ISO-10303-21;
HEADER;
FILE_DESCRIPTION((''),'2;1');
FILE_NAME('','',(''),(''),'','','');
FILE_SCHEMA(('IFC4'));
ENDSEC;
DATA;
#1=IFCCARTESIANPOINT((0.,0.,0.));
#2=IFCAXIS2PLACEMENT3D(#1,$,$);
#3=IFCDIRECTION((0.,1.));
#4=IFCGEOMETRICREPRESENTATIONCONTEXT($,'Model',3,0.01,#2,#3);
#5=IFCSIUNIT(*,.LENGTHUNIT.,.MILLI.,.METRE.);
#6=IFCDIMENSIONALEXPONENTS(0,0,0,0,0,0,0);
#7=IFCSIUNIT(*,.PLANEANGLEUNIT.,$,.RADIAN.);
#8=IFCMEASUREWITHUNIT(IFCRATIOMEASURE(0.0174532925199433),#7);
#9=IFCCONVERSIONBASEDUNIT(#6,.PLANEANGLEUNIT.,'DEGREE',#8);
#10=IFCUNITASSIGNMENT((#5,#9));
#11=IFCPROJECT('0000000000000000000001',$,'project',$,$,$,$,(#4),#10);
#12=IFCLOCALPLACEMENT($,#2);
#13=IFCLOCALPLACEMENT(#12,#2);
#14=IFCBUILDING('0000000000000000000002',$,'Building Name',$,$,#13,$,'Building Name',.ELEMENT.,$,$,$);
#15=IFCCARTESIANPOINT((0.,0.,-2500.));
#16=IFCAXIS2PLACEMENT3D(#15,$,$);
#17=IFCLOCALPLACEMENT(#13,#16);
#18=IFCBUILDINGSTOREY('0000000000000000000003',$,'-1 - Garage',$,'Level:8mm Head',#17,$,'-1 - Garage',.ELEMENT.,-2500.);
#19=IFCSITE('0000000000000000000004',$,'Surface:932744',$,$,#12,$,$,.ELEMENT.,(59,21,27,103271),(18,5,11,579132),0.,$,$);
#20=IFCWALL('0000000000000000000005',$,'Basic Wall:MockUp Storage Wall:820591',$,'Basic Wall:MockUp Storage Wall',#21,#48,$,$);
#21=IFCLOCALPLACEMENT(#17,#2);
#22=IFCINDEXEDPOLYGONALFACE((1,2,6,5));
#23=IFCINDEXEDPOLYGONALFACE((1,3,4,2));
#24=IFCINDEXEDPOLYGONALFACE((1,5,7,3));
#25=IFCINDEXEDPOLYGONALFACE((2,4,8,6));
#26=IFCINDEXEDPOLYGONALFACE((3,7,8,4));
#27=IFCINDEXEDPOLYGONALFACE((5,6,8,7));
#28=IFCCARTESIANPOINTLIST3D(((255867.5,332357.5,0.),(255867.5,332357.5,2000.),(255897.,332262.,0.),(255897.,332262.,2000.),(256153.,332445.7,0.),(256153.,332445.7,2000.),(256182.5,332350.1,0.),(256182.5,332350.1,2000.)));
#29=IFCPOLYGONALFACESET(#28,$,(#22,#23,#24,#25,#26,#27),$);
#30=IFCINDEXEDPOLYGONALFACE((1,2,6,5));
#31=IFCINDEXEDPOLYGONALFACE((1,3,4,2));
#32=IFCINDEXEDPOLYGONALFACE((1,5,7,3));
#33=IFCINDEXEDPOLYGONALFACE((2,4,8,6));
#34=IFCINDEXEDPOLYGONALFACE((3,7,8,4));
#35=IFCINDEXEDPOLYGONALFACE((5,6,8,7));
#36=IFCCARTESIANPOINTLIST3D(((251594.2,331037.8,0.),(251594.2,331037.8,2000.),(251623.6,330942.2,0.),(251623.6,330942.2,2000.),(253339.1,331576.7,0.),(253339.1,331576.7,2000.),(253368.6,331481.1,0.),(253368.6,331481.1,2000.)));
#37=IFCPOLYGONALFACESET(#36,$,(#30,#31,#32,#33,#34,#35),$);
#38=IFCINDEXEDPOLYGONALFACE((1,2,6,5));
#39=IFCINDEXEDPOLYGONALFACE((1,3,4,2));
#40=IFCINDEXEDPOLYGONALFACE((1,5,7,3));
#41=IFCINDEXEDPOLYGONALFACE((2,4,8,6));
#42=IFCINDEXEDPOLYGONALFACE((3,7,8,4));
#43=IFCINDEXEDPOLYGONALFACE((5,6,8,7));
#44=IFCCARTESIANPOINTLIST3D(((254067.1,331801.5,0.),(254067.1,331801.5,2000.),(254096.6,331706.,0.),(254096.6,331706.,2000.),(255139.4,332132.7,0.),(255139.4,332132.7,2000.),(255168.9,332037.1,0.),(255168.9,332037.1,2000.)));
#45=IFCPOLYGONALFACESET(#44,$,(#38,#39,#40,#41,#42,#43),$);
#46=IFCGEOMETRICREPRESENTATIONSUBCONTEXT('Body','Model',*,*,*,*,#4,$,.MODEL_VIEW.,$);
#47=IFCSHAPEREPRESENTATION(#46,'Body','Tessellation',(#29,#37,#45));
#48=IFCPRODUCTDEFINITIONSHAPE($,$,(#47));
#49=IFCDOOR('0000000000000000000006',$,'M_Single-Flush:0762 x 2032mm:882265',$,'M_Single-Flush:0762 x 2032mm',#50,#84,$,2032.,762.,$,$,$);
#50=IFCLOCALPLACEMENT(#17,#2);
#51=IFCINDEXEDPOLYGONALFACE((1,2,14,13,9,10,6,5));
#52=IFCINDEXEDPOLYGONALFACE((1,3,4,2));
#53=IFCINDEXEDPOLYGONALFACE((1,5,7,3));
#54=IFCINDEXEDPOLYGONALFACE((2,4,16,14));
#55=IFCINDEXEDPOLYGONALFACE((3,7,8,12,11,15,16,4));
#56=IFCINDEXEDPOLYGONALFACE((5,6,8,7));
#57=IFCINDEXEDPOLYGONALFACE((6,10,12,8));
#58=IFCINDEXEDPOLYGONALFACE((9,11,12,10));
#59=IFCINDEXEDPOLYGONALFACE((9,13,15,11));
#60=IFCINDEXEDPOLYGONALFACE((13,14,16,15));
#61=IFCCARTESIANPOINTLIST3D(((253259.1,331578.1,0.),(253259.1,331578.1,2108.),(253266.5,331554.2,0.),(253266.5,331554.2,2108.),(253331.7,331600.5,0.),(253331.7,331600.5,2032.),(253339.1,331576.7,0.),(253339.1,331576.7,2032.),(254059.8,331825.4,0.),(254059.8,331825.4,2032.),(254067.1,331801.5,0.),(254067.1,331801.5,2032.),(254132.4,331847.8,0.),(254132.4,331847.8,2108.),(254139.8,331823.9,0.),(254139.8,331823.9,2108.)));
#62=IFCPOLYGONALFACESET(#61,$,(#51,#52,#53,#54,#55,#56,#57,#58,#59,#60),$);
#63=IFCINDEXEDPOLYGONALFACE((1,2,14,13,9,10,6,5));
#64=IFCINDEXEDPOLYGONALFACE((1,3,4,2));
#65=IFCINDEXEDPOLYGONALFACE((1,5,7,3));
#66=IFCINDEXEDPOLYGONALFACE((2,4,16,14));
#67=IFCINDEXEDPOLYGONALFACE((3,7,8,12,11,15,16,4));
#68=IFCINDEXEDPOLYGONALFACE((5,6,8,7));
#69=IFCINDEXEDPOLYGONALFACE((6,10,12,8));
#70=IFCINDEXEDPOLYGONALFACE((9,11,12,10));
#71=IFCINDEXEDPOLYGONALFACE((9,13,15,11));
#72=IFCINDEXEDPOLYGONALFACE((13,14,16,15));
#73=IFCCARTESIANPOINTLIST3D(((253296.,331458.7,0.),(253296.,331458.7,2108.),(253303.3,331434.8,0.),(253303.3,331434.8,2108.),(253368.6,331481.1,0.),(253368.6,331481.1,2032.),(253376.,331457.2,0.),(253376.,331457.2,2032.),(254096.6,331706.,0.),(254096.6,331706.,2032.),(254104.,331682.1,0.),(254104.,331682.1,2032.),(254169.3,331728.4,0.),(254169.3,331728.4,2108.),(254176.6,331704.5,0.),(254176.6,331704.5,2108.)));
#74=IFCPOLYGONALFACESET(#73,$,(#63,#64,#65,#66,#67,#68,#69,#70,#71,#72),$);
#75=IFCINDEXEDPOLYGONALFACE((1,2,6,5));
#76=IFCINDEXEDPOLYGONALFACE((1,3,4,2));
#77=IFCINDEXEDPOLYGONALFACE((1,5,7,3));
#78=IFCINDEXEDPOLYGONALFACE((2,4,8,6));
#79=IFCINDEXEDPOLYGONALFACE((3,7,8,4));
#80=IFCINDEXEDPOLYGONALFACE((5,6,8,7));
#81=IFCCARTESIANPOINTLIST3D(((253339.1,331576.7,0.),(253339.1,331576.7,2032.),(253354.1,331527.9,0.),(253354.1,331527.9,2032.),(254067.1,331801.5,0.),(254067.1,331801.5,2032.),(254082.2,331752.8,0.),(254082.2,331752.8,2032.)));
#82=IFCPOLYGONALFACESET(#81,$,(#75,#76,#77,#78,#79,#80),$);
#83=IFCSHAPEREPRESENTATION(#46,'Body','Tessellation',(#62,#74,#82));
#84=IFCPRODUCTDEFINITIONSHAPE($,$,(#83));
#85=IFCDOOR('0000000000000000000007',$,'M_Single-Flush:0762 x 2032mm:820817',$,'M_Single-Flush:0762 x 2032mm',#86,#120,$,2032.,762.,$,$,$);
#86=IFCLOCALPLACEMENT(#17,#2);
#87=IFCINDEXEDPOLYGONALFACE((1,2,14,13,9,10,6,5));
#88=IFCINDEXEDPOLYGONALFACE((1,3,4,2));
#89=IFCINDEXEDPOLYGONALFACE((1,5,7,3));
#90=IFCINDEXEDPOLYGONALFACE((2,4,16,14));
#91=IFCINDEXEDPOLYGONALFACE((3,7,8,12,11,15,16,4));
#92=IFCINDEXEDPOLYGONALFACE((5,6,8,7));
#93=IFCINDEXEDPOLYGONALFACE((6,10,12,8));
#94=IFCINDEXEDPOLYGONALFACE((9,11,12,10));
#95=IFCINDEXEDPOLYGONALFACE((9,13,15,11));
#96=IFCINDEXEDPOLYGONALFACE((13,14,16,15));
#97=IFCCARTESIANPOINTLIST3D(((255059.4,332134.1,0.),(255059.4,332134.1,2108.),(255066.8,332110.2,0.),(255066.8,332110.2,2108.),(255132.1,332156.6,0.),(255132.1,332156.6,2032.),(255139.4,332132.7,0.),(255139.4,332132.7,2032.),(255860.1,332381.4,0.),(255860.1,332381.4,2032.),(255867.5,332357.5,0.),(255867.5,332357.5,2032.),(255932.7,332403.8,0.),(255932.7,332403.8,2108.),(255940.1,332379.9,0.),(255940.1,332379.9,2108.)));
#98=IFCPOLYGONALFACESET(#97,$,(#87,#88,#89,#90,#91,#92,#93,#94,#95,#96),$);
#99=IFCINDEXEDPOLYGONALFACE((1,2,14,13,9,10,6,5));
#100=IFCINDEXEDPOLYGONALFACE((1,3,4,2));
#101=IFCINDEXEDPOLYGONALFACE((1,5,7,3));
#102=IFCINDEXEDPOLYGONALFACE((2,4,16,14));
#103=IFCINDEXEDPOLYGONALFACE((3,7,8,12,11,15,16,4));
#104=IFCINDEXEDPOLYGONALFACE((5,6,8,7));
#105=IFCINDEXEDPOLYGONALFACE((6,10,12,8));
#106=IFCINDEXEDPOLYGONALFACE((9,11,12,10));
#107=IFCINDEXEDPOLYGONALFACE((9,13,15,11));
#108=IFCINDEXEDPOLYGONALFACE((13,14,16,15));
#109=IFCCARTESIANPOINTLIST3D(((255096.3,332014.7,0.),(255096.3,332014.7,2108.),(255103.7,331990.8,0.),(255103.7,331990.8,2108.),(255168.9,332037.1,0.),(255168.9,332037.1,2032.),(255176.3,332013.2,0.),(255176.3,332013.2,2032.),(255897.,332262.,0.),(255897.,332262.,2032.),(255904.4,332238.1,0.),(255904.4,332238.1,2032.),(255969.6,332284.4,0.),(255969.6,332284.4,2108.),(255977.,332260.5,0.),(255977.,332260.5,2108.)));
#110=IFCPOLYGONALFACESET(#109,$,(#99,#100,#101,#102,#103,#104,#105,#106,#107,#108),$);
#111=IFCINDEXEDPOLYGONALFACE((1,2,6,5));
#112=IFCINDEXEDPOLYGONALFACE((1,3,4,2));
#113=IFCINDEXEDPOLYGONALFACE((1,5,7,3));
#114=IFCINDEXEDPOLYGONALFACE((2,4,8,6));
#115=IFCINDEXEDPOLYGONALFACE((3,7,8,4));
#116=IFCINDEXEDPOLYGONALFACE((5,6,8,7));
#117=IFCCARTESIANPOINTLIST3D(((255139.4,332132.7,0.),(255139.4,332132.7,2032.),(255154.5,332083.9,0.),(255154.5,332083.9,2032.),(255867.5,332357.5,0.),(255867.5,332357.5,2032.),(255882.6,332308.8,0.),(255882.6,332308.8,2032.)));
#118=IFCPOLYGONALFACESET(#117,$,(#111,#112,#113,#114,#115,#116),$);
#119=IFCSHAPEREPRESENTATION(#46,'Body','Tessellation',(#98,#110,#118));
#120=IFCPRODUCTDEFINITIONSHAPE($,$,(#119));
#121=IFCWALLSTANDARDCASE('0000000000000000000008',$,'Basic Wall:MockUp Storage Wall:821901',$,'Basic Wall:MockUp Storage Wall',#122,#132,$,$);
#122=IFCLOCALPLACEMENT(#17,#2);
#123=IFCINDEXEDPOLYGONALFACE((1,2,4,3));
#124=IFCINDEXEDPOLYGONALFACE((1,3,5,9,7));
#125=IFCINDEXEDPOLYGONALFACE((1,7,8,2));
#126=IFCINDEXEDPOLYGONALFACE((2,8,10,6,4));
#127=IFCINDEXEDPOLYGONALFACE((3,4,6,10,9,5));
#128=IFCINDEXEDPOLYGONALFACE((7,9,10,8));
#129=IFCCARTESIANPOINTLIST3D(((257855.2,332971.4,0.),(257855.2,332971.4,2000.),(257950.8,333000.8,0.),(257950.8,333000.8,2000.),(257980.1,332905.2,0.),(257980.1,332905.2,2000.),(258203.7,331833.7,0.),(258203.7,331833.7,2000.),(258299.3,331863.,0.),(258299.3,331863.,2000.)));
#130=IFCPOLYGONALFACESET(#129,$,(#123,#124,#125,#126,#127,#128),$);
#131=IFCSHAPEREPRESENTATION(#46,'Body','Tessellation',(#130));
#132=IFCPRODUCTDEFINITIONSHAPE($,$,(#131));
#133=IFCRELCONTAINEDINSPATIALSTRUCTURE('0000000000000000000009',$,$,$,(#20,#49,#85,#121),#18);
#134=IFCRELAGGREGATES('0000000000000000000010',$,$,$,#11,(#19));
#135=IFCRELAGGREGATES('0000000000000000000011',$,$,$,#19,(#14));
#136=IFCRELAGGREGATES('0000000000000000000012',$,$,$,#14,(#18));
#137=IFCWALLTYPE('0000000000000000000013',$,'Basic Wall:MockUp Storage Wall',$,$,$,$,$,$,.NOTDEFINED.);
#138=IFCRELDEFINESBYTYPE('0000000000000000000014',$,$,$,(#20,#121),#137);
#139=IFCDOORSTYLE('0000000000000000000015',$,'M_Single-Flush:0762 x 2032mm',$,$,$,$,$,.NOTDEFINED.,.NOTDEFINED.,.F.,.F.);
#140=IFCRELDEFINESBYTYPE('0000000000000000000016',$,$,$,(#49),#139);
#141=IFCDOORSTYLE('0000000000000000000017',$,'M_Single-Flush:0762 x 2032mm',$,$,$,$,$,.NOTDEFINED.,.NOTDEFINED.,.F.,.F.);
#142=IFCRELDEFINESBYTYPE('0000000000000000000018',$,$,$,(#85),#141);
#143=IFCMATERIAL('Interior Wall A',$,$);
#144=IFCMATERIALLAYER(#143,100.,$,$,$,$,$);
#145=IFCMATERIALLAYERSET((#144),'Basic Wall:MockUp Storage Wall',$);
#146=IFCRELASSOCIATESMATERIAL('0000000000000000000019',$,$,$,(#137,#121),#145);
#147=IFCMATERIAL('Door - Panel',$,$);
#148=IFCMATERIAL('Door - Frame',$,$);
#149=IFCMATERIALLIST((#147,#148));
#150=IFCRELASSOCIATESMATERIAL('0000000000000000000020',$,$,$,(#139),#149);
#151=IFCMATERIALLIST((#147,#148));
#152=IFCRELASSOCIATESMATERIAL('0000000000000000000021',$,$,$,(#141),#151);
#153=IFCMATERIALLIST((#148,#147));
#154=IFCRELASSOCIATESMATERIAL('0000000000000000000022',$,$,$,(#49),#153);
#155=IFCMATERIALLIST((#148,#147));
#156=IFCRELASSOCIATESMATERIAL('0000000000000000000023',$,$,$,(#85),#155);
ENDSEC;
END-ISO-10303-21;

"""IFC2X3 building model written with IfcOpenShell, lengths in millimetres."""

from ifc_helpers import new_model, entity, si_unit, converted_unit, direction, frame, frame_2d, origin, origin_2d_with_axis, place, context, subcontext, project, spatial, polyline, rectangle, outline, extrude, source, transform, mapped, material, material_list, layer, layer_set, layer_usage, type_object, type_shapes, element, fill, save


model = new_model("IFC2X3")

# Units and contexts
model_context = context("Model", 3, precision=0.01, world=origin(), true_north=direction((0.0, 1.0)))
body_context = subcontext(model_context, "Body", "Model", "MODEL_VIEW")
ifc_project = project(units=[si_unit("LENGTHUNIT", "METRE", prefix="MILLI"), converted_unit("PLANEANGLEUNIT", "DEGREE", entity("IfcRatioMeasure", 0.0174532925199433), si_unit("PLANEANGLEUNIT", "RADIAN"), dimensions=[0, 0, 0, 0, 0, 0, 0])], contexts=[model_context])

# Site, building, storey
site_placement = place(None, origin())
site = spatial("IfcSite", under=ifc_project, at=site_placement, Name="Surface:932744", CompositionType="ELEMENT", RefLatitude=(59, 21, 27, 103271), RefLongitude=(18, 5, 11, 579132), RefElevation=0.0)
building_placement = place(site_placement, origin())
building = spatial("IfcBuilding", under=site, at=building_placement, Name="Building Name", LongName="Building Name", CompositionType="ELEMENT")
storey_placement = place(building_placement, frame((0.0, 0.0, -2500.0)))
storey = spatial("IfcBuildingStorey", under=building, at=storey_placement, Name="-1 - Garage", ObjectType="Level:8mm Head", LongName="-1 - Garage", CompositionType="ELEMENT", Elevation=-2500.0)

# Shared definitions
ifc_material_1 = material(Name="Door - Frame")
ifc_material_2 = material(Name="Door - Panel")

# Shared definitions
ifc_material_3 = material(Name="Interior Wall A")
ifc_layer_1 = layer(ifc_material_3, 100.0)
ifc_layer_set_1 = layer_set([ifc_layer_1], Name="Basic Wall:MockUp Storage Wall")
wall_type_1 = type_object("IfcWallType", Name="Basic Wall:MockUp Storage Wall", PredefinedType="NOTDEFINED", material=ifc_layer_set_1)
ifc_material_list_1 = material_list([ifc_material_2, ifc_material_1])
door_style_1 = type_object("IfcDoorStyle", Name="M_Single-Flush:0762 x 2032mm", ConstructionType="NOTDEFINED", OperationType="NOTDEFINED", ParameterTakesPrecedence=False, Sizeable=False, material=ifc_material_list_1)
shared_shape_1 = source(origin(), body_context, "Body", "SweptSolid", [
    extrude(outline(polyline([(-457.0, -1073.0), (457.0, -1073.0), (457.0, 1035.0), (381.0, 1035.0), (381.0, -997.0), (-381.0, -997.0), (-381.0, 1035.0), (-457.0, 1035.0), (-457.0, -1073.0)])), frame((381.0, 125.0, 1035.0), z_axis=(0.0, -1.0, 0.0), x_axis=(-1.0, 0.0, 0.0)), (0.0, 0.0, 1.0), 25.0),
    extrude(outline(polyline([(-1073.0, -457.0), (1035.0, -457.0), (1035.0, -381.0), (-997.0, -381.0), (-997.0, 381.0), (1035.0, 381.0), (1035.0, 457.0), (-1073.0, 457.0), (-1073.0, -457.0)])), frame((381.0, 0.0, 1035.0), z_axis=(0.0, -1.0, 0.0), x_axis=(0.0, 0.0, -1.0)), (0.0, 0.0, 1.0), 25.0),
    extrude(rectangle(XDim=762.0, YDim=51.0, at=origin_2d_with_axis()), frame((381.0, 74.5, 0.0)), (0.0, 0.0, 1.0), 2032.0),
])
type_shapes(door_style_1, [shared_shape_1])
ifc_material_list_2 = material_list([ifc_material_2, ifc_material_1])
door_style_2 = type_object("IfcDoorStyle", Name="M_Single-Flush:0762 x 2032mm", ConstructionType="NOTDEFINED", OperationType="NOTDEFINED", ParameterTakesPrecedence=False, Sizeable=False, material=ifc_material_list_2)
shared_shape_2 = source(origin(), body_context, "Body", "SweptSolid", [
    extrude(outline(polyline([(-457.0, -1073.0), (457.0, -1073.0), (457.0, 1035.0), (381.0, 1035.0), (381.0, -997.0), (-381.0, -997.0), (-381.0, 1035.0), (-457.0, 1035.0), (-457.0, -1073.0)])), frame((381.0, 100.0, 1035.0), z_axis=(0.0, 1.0, 0.0), x_axis=(1.0, 0.0, 0.0)), (0.0, 0.0, 1.0), 25.0),
    extrude(outline(polyline([(-1073.0, -457.0), (1035.0, -457.0), (1035.0, -381.0), (-997.0, -381.0), (-997.0, 381.0), (1035.0, 381.0), (1035.0, 457.0), (-1073.0, 457.0), (-1073.0, -457.0)])), frame((381.0, -25.0, 1035.0), z_axis=(0.0, 1.0, 0.0), x_axis=(0.0, 0.0, -1.0)), (0.0, 0.0, 1.0), 25.0),
    extrude(rectangle(XDim=51.0, YDim=762.0, at=origin_2d_with_axis()), frame((381.0, 74.5, 0.0), z_axis=(0.0, 0.0, 1.0), x_axis=(0.0, 1.0, 0.0)), (0.0, 0.0, 1.0), 2032.0),
])
type_shapes(door_style_2, [shared_shape_2])

# Wall, openings, doors
wall_1_placement = place(storey_placement, frame((256167.8, 332397.9, 0.0), z_axis=(0.0, 0.0, 1.0), x_axis=(-0.955473, -0.29508, 0.0)))
wall_1 = element("IfcWall", 1, at=wall_1_placement, inside=storey, type_object=wall_type_1, Name="Basic Wall:MockUp Storage Wall:820591", ObjectType="Basic Wall:MockUp Storage Wall", context=body_context, shape_type="SweptSolid", body=[
    extrude(rectangle(XDim=100.0, YDim=298.8, at=frame_2d((-10.0, -9.9), x_axis=(1.0, 0.0))), frame((139.5, 10.0, 0.0), z_axis=(0.0, 0.0, 1.0), x_axis=(0.0, 1.0, 0.0)), (0.0, 0.0, 1.0), 2000.0),
    extrude(outline(polyline([(-938.9, -28.6), (-838.9, -28.6), (421.0, -28.6), (521.0, -28.6), (887.3, -28.6), (887.3, 71.4), (-938.8, 71.4), (-938.9, -28.6)])), frame((3832.4, 21.4, 0.0), z_axis=(0.0, 0.0, 1.0), x_axis=(-1.0, 0.0, 0.0)), (0.0, 0.0, 1.0), 2000.0),
    extrude(rectangle(XDim=1122.3, YDim=100.0, at=frame_2d((-13.1, -16.7), x_axis=(1.0, 0.0))), frame((1635.1, 16.7, 0.0)), (0.0, 0.0, 1.0), 2000.0),
])
opening_1_placement = place(wall_1_placement, frame((1060.8, 50.0, 0.0)))
opening_1 = element("IfcOpeningElement", 2, at=opening_1_placement, cuts=wall_1, ObjectType="Opening", context=body_context, shape_type="SweptSolid", body=[
    extrude(rectangle(XDim=762.0, YDim=2032.0, at=frame_2d((1016.0, 381.0), x_axis=(0.0, 1.0))), frame((0.0, 0.0, 0.0), z_axis=(0.0, -1.0, 0.0), x_axis=(0.0, 0.0, 1.0)), (0.0, 0.0, 1.0), 100.0),
])
opening_2_placement = place(wall_1_placement, frame((2945.1, 50.0, 0.0)))
opening_2 = element("IfcOpeningElement", 3, at=opening_2_placement, cuts=wall_1, ObjectType="Opening", context=body_context, shape_type="SweptSolid", body=[
    extrude(rectangle(XDim=762.0, YDim=2032.0, at=frame_2d((1016.0, 381.0), x_axis=(0.0, -1.0))), frame((0.0, 0.0, 0.0), z_axis=(0.0, -1.0, 0.0), x_axis=(0.0, 0.0, 1.0)), (0.0, 0.0, 1.0), 100.0),
])
ifc_material_list_3 = material_list([ifc_material_1, ifc_material_2])
door_1_placement = place(opening_2_placement, frame((0.0, 0.0, 0.0), z_axis=(0.0, 0.0, 1.0), x_axis=(-1.0, 0.0, 0.0)))
door_1 = element("IfcDoor", 4, at=door_1_placement, inside=storey, type_object=door_style_1, material=ifc_material_list_3, Name="M_Single-Flush:0762 x 2032mm:882265", ObjectType="M_Single-Flush:0762 x 2032mm", OverallHeight=2032.0, OverallWidth=762.0, context=body_context, shape_type="MappedRepresentation", body=[
    mapped(shared_shape_1, transform((0.0, 0.0, 0.0), scale=1.0)),
])
fill(opening_2, door_1)
ifc_material_list_4 = material_list([ifc_material_1, ifc_material_2])
door_2_placement = place(opening_1_placement, frame((0.0, 0.0, 0.0), z_axis=(0.0, 0.0, 1.0), x_axis=(-1.0, 0.0, 0.0)))
door_2 = element("IfcDoor", 5, at=door_2_placement, inside=storey, type_object=door_style_2, material=ifc_material_list_4, Name="M_Single-Flush:0762 x 2032mm:820817", ObjectType="M_Single-Flush:0762 x 2032mm", OverallHeight=2032.0, OverallWidth=762.0, context=body_context, shape_type="MappedRepresentation", body=[
    mapped(shared_shape_2, transform((0.0, 0.0, 0.0), scale=1.0)),
])
fill(opening_1, door_2)

# Wall
ifc_layer_usage_1 = layer_usage(ifc_layer_set_1, "AXIS2", "NEGATIVE", 50.0)
wall_2_placement = place(storey_placement, frame((257903.0, 332986.2, 0.0), z_axis=(0.0, 0.0, 1.0), x_axis=(0.29288, -0.956149, 0.0)))
element("IfcWallStandardCase", 6, at=wall_2_placement, inside=storey, type_object=wall_type_1, material=ifc_layer_usage_1, Name="Basic Wall:MockUp Storage Wall:821901", ObjectType="Basic Wall:MockUp Storage Wall", context=body_context, shape_type="SweptSolid", body=[
    extrude(outline(polyline([(1190.1, -50.0), (1190.1, 50.0), (100.0, 50.0), (0.0, 50.0), (0.1, -50.0), (1190.1, -50.0)])), origin(), (0.0, 0.0, 1.0), 2000.0),
])

save(model, "model.ifc")
